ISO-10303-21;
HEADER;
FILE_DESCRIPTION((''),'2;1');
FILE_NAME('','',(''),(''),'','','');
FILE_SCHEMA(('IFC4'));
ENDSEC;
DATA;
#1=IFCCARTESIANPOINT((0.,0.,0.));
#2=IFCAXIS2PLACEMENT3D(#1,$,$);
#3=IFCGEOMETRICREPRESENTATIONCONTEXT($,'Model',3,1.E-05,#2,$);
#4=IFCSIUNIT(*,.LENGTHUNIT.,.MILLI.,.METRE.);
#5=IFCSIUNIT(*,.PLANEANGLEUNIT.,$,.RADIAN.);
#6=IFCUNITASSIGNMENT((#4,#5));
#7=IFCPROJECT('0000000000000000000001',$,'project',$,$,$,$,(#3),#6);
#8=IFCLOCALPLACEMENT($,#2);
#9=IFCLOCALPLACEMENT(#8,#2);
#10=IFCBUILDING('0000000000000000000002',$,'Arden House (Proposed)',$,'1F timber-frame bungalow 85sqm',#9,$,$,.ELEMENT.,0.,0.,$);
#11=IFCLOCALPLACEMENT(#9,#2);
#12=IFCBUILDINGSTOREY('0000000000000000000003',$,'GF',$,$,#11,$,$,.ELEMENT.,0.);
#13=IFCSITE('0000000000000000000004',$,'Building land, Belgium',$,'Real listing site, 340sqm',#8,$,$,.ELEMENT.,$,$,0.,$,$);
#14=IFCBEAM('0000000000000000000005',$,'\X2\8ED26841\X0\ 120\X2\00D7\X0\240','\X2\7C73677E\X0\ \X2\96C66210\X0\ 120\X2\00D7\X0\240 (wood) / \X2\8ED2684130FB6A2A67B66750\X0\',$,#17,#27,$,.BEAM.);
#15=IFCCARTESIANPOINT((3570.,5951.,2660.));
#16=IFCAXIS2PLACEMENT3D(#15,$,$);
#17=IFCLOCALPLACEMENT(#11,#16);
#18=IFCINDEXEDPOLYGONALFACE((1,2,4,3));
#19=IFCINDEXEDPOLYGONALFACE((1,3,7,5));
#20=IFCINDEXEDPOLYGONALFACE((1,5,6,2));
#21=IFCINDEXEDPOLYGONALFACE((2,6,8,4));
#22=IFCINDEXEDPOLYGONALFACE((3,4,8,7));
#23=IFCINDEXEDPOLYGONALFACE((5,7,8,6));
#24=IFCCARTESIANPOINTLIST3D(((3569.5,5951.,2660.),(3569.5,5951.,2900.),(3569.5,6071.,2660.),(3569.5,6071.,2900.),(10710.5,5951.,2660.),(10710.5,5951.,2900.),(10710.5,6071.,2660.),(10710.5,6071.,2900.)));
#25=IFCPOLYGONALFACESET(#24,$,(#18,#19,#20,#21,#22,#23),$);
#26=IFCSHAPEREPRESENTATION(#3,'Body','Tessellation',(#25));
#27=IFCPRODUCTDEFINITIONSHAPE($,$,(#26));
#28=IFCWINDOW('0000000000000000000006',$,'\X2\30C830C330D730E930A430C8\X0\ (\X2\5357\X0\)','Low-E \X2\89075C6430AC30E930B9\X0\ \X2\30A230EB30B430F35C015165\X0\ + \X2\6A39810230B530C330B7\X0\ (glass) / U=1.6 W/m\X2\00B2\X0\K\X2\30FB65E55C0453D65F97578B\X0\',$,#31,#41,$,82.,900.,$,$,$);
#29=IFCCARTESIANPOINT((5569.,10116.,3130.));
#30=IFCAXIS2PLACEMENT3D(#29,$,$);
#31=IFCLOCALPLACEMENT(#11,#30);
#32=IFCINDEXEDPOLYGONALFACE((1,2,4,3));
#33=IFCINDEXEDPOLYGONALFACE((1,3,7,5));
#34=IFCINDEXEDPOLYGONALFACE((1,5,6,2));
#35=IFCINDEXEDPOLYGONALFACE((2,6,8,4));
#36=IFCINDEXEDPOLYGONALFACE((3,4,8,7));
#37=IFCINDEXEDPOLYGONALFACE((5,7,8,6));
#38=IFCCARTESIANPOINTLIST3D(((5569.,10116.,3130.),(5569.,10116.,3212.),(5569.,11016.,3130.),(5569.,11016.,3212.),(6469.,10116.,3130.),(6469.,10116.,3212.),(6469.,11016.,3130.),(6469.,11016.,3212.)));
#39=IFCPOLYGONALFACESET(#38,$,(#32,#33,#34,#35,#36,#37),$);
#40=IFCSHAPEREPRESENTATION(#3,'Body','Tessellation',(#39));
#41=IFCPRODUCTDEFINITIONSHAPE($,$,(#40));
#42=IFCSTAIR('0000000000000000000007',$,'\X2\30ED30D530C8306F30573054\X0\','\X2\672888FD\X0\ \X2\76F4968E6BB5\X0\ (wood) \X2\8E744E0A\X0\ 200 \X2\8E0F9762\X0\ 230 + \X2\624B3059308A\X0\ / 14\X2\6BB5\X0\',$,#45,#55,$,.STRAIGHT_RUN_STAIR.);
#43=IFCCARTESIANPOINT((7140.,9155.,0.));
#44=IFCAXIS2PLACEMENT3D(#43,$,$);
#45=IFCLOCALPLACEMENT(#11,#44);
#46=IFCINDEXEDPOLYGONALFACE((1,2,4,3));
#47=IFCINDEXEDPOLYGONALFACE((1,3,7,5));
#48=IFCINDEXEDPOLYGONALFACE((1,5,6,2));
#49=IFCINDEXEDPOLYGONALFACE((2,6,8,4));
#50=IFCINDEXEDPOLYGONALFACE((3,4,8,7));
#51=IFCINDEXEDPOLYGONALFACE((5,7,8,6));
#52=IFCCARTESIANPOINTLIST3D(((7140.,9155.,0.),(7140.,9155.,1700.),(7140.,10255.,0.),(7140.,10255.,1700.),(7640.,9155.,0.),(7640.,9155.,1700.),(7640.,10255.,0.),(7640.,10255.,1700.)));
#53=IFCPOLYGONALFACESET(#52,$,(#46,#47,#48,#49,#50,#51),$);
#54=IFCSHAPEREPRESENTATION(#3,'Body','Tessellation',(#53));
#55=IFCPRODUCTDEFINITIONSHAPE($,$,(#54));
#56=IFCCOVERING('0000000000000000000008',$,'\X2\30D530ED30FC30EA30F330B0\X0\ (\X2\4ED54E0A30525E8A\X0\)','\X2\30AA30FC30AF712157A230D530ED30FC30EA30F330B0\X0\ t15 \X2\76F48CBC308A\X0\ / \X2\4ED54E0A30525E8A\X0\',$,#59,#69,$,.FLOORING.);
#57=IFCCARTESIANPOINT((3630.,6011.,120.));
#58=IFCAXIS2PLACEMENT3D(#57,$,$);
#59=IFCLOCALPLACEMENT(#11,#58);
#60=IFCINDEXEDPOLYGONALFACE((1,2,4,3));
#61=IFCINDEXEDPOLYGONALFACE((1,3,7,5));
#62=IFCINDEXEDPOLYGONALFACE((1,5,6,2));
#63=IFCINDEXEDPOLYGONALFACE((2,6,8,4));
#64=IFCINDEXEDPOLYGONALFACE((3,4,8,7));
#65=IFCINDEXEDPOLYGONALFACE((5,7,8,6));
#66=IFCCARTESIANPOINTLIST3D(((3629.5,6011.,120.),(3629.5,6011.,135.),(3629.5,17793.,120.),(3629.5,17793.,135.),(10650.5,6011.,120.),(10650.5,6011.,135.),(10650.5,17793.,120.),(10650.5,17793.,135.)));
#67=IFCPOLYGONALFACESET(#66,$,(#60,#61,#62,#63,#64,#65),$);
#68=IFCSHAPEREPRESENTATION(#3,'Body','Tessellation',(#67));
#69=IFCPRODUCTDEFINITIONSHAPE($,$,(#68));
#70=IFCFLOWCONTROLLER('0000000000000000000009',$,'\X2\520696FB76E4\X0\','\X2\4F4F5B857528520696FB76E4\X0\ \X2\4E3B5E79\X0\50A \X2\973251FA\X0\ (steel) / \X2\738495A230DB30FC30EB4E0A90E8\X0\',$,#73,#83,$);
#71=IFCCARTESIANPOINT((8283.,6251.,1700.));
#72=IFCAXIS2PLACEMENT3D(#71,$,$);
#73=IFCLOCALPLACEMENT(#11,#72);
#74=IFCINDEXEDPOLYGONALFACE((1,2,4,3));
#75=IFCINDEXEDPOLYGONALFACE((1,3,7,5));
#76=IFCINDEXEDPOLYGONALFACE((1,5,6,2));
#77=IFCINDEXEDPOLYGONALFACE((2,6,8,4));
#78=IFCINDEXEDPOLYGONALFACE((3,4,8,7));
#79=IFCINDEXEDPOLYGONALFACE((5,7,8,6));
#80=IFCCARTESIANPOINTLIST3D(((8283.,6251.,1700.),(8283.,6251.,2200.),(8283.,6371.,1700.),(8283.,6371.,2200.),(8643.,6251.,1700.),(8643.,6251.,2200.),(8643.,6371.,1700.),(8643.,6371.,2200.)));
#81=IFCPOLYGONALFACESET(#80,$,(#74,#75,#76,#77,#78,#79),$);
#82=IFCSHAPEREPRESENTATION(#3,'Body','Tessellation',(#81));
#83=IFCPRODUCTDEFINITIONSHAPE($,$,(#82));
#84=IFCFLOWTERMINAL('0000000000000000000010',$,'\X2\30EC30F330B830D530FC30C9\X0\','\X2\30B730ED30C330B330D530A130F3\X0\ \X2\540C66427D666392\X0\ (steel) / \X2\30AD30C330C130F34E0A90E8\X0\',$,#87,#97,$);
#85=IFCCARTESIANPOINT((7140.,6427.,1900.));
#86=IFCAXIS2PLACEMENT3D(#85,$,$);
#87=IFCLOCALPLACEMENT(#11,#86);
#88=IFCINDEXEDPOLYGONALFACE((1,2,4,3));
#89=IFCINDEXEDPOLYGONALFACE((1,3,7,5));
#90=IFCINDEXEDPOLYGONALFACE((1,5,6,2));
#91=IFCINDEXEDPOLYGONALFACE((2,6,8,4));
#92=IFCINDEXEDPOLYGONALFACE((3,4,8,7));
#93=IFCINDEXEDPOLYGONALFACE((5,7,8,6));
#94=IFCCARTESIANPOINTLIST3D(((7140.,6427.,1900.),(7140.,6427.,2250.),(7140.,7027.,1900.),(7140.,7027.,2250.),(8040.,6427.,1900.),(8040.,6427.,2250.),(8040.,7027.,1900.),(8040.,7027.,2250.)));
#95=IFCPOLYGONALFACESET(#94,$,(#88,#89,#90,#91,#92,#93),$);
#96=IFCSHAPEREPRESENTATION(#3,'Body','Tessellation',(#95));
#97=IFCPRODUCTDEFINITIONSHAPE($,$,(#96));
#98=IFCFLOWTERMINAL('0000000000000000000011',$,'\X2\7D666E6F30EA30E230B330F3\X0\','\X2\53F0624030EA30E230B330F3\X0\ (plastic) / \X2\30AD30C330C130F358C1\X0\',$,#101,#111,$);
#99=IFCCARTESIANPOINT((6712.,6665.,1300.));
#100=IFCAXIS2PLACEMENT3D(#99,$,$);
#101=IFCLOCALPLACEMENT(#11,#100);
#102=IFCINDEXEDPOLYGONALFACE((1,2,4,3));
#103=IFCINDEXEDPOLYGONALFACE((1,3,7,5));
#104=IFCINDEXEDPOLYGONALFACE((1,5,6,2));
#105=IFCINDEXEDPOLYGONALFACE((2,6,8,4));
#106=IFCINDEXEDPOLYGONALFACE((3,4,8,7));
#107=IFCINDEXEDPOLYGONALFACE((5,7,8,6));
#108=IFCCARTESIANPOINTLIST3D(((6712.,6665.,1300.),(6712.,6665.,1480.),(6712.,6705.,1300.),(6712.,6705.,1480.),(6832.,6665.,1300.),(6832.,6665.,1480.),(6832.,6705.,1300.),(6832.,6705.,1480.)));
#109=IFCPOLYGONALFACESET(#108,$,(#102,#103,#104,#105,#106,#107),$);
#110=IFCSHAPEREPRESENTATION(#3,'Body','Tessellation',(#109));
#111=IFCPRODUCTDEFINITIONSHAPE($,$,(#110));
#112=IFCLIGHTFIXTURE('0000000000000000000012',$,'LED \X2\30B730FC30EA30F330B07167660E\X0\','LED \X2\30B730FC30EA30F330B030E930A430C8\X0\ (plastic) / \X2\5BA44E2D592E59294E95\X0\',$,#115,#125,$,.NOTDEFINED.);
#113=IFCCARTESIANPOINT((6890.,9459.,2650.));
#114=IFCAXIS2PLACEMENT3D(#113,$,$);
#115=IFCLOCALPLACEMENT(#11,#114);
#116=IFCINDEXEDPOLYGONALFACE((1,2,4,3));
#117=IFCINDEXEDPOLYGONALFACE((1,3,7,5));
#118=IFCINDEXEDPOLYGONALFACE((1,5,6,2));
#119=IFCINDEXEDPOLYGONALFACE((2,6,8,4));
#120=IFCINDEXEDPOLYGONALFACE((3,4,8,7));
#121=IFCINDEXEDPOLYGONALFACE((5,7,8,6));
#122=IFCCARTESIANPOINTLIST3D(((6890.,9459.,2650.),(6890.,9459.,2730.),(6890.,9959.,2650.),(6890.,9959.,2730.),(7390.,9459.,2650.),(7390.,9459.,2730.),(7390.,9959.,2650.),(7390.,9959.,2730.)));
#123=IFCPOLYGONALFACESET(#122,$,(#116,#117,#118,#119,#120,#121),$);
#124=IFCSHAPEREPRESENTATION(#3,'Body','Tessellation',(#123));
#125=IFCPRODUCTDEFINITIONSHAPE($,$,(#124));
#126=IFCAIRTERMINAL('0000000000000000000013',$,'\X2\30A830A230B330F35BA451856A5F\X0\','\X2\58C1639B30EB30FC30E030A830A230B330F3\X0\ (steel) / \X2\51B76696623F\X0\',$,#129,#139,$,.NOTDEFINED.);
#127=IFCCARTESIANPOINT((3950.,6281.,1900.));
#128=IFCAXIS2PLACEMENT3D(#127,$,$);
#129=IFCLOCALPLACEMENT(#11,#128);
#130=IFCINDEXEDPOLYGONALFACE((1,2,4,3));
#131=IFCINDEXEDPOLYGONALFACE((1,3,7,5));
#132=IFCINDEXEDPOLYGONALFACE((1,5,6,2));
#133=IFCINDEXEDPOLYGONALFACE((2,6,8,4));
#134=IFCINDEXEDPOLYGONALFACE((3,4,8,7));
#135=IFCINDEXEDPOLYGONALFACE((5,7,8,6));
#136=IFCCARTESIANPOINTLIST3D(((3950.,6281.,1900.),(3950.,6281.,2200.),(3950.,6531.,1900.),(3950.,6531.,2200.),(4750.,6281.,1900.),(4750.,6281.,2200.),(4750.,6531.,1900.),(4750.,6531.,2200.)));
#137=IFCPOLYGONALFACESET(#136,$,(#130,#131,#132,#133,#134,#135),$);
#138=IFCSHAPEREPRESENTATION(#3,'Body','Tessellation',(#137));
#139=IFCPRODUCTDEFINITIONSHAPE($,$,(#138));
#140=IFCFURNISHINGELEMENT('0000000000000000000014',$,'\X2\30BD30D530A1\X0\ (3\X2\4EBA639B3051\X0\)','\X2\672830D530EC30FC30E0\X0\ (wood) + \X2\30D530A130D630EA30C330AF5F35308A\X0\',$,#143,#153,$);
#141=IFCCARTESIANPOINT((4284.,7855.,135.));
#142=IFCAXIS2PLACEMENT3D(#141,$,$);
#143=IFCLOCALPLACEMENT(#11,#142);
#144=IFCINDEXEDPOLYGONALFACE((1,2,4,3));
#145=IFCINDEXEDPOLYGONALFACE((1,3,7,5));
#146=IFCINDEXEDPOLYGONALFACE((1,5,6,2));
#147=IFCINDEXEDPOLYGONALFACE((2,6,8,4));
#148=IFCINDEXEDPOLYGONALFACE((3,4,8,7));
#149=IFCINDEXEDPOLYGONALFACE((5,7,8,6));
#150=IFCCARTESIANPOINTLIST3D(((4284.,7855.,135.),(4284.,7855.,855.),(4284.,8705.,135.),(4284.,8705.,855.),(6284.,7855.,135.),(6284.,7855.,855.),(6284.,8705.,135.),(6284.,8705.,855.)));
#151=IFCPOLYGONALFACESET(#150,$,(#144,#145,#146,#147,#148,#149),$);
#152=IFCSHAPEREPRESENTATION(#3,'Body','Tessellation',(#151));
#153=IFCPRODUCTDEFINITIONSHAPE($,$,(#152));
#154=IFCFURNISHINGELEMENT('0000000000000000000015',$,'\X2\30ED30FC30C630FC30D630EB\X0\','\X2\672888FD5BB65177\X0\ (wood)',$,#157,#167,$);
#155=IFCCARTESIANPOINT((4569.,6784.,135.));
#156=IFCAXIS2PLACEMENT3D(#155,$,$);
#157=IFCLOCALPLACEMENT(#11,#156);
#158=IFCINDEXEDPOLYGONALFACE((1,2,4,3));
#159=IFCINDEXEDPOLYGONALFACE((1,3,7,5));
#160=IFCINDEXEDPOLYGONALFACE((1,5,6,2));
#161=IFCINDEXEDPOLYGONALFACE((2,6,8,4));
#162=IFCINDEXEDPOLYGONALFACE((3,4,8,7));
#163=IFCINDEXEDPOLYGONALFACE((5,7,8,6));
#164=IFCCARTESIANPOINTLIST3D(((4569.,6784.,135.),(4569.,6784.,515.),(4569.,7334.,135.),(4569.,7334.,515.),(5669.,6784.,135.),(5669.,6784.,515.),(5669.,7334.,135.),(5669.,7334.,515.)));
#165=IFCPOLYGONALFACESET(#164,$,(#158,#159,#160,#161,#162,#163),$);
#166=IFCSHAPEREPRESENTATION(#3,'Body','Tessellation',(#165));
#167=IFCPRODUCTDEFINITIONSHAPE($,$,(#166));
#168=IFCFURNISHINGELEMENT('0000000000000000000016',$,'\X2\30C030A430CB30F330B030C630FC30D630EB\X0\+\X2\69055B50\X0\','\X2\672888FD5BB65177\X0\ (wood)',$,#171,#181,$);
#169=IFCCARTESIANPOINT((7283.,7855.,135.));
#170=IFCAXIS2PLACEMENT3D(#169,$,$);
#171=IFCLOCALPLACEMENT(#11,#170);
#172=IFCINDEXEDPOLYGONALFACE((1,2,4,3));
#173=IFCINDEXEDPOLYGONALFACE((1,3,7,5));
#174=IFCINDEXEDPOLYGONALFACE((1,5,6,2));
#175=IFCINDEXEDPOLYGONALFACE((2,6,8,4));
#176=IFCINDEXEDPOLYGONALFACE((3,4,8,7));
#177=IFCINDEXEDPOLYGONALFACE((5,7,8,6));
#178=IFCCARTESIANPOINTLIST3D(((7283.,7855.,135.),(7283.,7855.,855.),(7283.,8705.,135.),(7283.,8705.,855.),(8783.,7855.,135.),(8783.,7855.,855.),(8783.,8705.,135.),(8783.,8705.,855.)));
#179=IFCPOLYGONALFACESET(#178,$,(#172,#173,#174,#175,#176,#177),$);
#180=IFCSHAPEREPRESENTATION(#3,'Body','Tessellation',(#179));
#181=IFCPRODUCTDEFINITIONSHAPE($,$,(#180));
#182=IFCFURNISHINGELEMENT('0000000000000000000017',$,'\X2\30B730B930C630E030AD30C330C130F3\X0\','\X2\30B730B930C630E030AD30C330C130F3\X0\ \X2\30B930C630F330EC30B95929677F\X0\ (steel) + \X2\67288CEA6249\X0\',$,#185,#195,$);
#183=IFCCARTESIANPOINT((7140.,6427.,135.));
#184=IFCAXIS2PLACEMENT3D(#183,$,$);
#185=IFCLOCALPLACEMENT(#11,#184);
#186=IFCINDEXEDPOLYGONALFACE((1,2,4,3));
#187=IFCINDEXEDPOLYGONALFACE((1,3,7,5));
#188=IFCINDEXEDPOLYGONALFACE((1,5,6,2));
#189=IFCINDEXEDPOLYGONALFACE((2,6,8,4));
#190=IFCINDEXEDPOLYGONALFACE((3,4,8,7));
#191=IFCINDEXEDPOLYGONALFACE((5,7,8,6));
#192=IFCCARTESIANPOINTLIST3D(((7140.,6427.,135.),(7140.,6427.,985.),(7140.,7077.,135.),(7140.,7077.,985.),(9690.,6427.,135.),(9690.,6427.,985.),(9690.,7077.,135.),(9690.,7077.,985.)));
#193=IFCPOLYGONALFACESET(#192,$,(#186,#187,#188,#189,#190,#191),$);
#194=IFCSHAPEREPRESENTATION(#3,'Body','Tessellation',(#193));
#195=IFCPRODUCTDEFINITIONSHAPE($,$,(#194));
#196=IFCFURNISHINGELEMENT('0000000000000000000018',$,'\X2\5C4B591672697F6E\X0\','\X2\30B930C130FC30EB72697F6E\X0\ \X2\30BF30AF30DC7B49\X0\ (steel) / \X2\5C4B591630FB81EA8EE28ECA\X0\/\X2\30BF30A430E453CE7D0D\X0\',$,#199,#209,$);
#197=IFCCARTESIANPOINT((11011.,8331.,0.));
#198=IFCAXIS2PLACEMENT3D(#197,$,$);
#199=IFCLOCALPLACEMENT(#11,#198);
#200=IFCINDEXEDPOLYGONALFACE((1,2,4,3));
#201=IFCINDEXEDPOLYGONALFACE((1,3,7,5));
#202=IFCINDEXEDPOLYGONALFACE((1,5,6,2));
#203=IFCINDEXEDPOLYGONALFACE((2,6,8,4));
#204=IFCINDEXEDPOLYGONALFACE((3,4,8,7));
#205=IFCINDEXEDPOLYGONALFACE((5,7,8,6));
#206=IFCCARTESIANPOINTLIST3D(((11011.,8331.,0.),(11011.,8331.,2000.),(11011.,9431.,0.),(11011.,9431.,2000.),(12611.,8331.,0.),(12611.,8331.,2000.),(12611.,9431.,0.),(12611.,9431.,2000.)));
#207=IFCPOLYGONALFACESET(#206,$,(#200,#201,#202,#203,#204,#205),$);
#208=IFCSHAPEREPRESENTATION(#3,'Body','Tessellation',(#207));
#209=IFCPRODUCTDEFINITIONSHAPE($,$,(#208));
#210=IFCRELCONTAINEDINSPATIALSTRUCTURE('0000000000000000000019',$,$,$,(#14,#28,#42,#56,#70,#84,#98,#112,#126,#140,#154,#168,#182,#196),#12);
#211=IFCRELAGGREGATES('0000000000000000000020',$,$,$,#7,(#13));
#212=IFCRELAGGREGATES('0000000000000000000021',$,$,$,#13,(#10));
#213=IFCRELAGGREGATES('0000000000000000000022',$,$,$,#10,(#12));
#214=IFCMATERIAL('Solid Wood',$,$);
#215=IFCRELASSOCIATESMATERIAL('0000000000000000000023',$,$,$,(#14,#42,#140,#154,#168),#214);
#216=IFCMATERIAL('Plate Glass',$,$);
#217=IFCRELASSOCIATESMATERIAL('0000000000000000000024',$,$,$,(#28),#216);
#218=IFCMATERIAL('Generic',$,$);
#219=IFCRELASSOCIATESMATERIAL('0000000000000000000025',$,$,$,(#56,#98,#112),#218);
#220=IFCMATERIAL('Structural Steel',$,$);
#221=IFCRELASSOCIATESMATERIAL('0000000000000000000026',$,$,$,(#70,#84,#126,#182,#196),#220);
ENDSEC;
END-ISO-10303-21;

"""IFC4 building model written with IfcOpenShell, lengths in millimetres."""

from ifc_helpers import new_model, si_unit, frame, frame_2d, origin, place, context, project, spatial, rectangle, extrude, material, element, save


model = new_model("IFC4")

# Units and contexts
model_context = context("Model", 3, precision=1e-05, world=origin())
ifc_project = project(units=[si_unit("LENGTHUNIT", "METRE", prefix="MILLI"), si_unit("PLANEANGLEUNIT", "RADIAN")], contexts=[model_context])

# Site, building, storey
site_placement = place(None, origin())
site = spatial("IfcSite", under=ifc_project, at=site_placement, Name="Building land, Belgium", ObjectType="Real listing site, 340sqm", CompositionType="ELEMENT", RefElevation=0.0)
building_placement = place(site_placement, origin())
building = spatial("IfcBuilding", under=site, at=building_placement, Name="Arden House (Proposed)", ObjectType="1F timber-frame bungalow 85sqm", CompositionType="ELEMENT", ElevationOfRefHeight=0.0, ElevationOfTerrain=0.0)
storey_placement = place(building_placement, origin())
storey = spatial("IfcBuildingStorey", under=building, at=storey_placement, Name="GF", CompositionType="ELEMENT", Elevation=0.0)

# Shared definitions
ifc_material_1 = material(Name="Solid Wood")

# Beam
beam_1_placement = place(storey_placement, frame((3570.0, 5951.0, 2660.0)))
element("IfcBeam", 1, at=beam_1_placement, inside=storey, material=ifc_material_1, Name="軒桁 120×240", Description="米松 集成 120×240 (wood) / 軒桁・横架材", PredefinedType="BEAM", context=model_context, shape_type="SweptSolid", body=[
    extrude(rectangle(XDim=7141.0, YDim=120.0, at=frame_2d((3570.0, 60.0))), frame((3570.0, 5951.0, 2660.0)), (0.0, 0.0, 1.0), 240.0),
])

# Window
ifc_material_2 = material(Name="Plate Glass")
window_placement = place(storey_placement, frame((5569.0, 10116.0, 3130.0)))
element("IfcWindow", 2, at=window_placement, inside=storey, material=ifc_material_2, Name="トップライト (南)", Description="Low-E 複層ガラス アルゴン封入 + 樹脂サッシ (glass) / U=1.6 W/m²K・日射取得型", OverallHeight=82.0, OverallWidth=900.0, context=model_context, shape_type="SweptSolid", body=[
    extrude(rectangle(XDim=900.0, YDim=900.0, at=frame_2d((450.0, 450.0))), frame((5569.0, 10116.0, 3130.0)), (0.0, 0.0, 1.0), 82.0),
])

# Stair
stair_placement = place(storey_placement, frame((7140.0, 9155.0, 0.0)))
element("IfcStair", 3, at=stair_placement, inside=storey, material=ifc_material_1, Name="ロフトはしご", Description="木製 直階段 (wood) 蹴上 200 踏面 230 + 手すり / 14段", PredefinedType="STRAIGHT_RUN_STAIR", context=model_context, shape_type="SweptSolid", body=[
    extrude(rectangle(XDim=500.0, YDim=1100.0, at=frame_2d((250.0, 550.0))), frame((7140.0, 9155.0, 0.0)), (0.0, 0.0, 1.0), 1700.0),
])

# Covering
ifc_material_3 = material(Name="Generic")
covering_placement = place(storey_placement, frame((3630.0, 6011.0, 120.0)))
element("IfcCovering", 4, at=covering_placement, inside=storey, material=ifc_material_3, Name="フローリング (仕上げ床)", Description="オーク無垢フローリング t15 直貼り / 仕上げ床", PredefinedType="FLOORING", context=model_context, shape_type="SweptSolid", body=[
    extrude(rectangle(XDim=7021.0, YDim=11782.0, at=frame_2d((3510.0, 5891.0))), frame((3630.0, 6011.0, 120.0)), (0.0, 0.0, 1.0), 15.0),
])

# Flow controller
ifc_material_4 = material(Name="Structural Steel")
flow_controller_placement = place(storey_placement, frame((8283.0, 6251.0, 1700.0)))
element("IfcFlowController", 5, at=flow_controller_placement, inside=storey, material=ifc_material_4, Name="分電盤", Description="住宅用分電盤 主幹50A 露出 (steel) / 玄関ホール上部", context=model_context, shape_type="SweptSolid", body=[
    extrude(rectangle(XDim=360.0, YDim=120.0, at=frame_2d((180.0, 60.0))), frame((8283.0, 6251.0, 1700.0)), (0.0, 0.0, 1.0), 500.0),
])

# Flow terminals
flow_terminal_1_placement = place(storey_placement, frame((7140.0, 6427.0, 1900.0)))
element("IfcFlowTerminal", 6, at=flow_terminal_1_placement, inside=storey, material=ifc_material_4, Name="レンジフード", Description="シロッコファン 同時給排 (steel) / キッチン上部", context=model_context, shape_type="SweptSolid", body=[
    extrude(rectangle(XDim=900.0, YDim=600.0, at=frame_2d((450.0, 300.0))), frame((7140.0, 6427.0, 1900.0)), (0.0, 0.0, 1.0), 350.0),
])
flow_terminal_2_placement = place(storey_placement, frame((6712.0, 6665.0, 1300.0)))
element("IfcFlowTerminal", 7, at=flow_terminal_2_placement, inside=storey, material=ifc_material_3, Name="給湯リモコン", Description="台所リモコン (plastic) / キッチン壁", context=model_context, shape_type="SweptSolid", body=[
    extrude(rectangle(XDim=120.0, YDim=40.0, at=frame_2d((60.0, 20.0))), frame((6712.0, 6665.0, 1300.0)), (0.0, 0.0, 1.0), 180.0),
])

# Light fixture
light_fixture_placement = place(storey_placement, frame((6890.0, 9459.0, 2650.0)))
element("IfcLightFixture", 8, at=light_fixture_placement, inside=storey, material=ifc_material_3, Name="LED シーリング照明", Description="LED シーリングライト (plastic) / 室中央天井", PredefinedType="NOTDEFINED", context=model_context, shape_type="SweptSolid", body=[
    extrude(rectangle(XDim=500.0, YDim=500.0, at=frame_2d((250.0, 250.0))), frame((6890.0, 9459.0, 2650.0)), (0.0, 0.0, 1.0), 80.0),
])

# Air terminal
air_terminal_placement = place(storey_placement, frame((3950.0, 6281.0, 1900.0)))
element("IfcAirTerminal", 9, at=air_terminal_placement, inside=storey, material=ifc_material_4, Name="エアコン室内機", Description="壁掛ルームエアコン (steel) / 冷暖房", PredefinedType="NOTDEFINED", context=model_context, shape_type="SweptSolid", body=[
    extrude(rectangle(XDim=800.0, YDim=250.0, at=frame_2d((400.0, 125.0))), frame((3950.0, 6281.0, 1900.0)), (0.0, 0.0, 1.0), 300.0),
])

# Furnishing elements
furnishing_1_placement = place(storey_placement, frame((4284.0, 7855.0, 135.0)))
element("IfcFurnishingElement", 10, at=furnishing_1_placement, inside=storey, material=ifc_material_1, Name="ソファ (3人掛け)", Description="木フレーム (wood) + ファブリック張り", context=model_context, shape_type="SweptSolid", body=[
    extrude(rectangle(XDim=2000.0, YDim=850.0, at=frame_2d((1000.0, 425.0))), frame((4284.0, 7855.0, 135.0)), (0.0, 0.0, 1.0), 720.0),
])
furnishing_2_placement = place(storey_placement, frame((4569.0, 6784.0, 135.0)))
element("IfcFurnishingElement", 11, at=furnishing_2_placement, inside=storey, material=ifc_material_1, Name="ローテーブル", Description="木製家具 (wood)", context=model_context, shape_type="SweptSolid", body=[
    extrude(rectangle(XDim=1100.0, YDim=550.0, at=frame_2d((550.0, 275.0))), frame((4569.0, 6784.0, 135.0)), (0.0, 0.0, 1.0), 380.0),
])
furnishing_3_placement = place(storey_placement, frame((7283.0, 7855.0, 135.0)))
element("IfcFurnishingElement", 12, at=furnishing_3_placement, inside=storey, material=ifc_material_1, Name="ダイニングテーブル+椅子", Description="木製家具 (wood)", context=model_context, shape_type="SweptSolid", body=[
    extrude(rectangle(XDim=1500.0, YDim=850.0, at=frame_2d((750.0, 425.0))), frame((7283.0, 7855.0, 135.0)), (0.0, 0.0, 1.0), 720.0),
])
furnishing_4_placement = place(storey_placement, frame((7140.0, 6427.0, 135.0)))
element("IfcFurnishingElement", 13, at=furnishing_4_placement, inside=storey, material=ifc_material_4, Name="システムキッチン", Description="システムキッチン ステンレス天板 (steel) + 木質扉", context=model_context, shape_type="SweptSolid", body=[
    extrude(rectangle(XDim=2550.0, YDim=650.0, at=frame_2d((1275.0, 325.0))), frame((7140.0, 6427.0, 135.0)), (0.0, 0.0, 1.0), 850.0),
])
furnishing_5_placement = place(storey_placement, frame((11011.0, 8331.0, 0.0)))
element("IfcFurnishingElement", 14, at=furnishing_5_placement, inside=storey, material=ifc_material_4, Name="屋外物置", Description="スチール物置 タクボ等 (steel) / 屋外・自転車/タイヤ収納", context=model_context, shape_type="SweptSolid", body=[
    extrude(rectangle(XDim=1600.0, YDim=1100.0, at=frame_2d((800.0, 550.0))), frame((11011.0, 8331.0, 0.0)), (0.0, 0.0, 1.0), 2000.0),
])

save(model, "model.ifc")
